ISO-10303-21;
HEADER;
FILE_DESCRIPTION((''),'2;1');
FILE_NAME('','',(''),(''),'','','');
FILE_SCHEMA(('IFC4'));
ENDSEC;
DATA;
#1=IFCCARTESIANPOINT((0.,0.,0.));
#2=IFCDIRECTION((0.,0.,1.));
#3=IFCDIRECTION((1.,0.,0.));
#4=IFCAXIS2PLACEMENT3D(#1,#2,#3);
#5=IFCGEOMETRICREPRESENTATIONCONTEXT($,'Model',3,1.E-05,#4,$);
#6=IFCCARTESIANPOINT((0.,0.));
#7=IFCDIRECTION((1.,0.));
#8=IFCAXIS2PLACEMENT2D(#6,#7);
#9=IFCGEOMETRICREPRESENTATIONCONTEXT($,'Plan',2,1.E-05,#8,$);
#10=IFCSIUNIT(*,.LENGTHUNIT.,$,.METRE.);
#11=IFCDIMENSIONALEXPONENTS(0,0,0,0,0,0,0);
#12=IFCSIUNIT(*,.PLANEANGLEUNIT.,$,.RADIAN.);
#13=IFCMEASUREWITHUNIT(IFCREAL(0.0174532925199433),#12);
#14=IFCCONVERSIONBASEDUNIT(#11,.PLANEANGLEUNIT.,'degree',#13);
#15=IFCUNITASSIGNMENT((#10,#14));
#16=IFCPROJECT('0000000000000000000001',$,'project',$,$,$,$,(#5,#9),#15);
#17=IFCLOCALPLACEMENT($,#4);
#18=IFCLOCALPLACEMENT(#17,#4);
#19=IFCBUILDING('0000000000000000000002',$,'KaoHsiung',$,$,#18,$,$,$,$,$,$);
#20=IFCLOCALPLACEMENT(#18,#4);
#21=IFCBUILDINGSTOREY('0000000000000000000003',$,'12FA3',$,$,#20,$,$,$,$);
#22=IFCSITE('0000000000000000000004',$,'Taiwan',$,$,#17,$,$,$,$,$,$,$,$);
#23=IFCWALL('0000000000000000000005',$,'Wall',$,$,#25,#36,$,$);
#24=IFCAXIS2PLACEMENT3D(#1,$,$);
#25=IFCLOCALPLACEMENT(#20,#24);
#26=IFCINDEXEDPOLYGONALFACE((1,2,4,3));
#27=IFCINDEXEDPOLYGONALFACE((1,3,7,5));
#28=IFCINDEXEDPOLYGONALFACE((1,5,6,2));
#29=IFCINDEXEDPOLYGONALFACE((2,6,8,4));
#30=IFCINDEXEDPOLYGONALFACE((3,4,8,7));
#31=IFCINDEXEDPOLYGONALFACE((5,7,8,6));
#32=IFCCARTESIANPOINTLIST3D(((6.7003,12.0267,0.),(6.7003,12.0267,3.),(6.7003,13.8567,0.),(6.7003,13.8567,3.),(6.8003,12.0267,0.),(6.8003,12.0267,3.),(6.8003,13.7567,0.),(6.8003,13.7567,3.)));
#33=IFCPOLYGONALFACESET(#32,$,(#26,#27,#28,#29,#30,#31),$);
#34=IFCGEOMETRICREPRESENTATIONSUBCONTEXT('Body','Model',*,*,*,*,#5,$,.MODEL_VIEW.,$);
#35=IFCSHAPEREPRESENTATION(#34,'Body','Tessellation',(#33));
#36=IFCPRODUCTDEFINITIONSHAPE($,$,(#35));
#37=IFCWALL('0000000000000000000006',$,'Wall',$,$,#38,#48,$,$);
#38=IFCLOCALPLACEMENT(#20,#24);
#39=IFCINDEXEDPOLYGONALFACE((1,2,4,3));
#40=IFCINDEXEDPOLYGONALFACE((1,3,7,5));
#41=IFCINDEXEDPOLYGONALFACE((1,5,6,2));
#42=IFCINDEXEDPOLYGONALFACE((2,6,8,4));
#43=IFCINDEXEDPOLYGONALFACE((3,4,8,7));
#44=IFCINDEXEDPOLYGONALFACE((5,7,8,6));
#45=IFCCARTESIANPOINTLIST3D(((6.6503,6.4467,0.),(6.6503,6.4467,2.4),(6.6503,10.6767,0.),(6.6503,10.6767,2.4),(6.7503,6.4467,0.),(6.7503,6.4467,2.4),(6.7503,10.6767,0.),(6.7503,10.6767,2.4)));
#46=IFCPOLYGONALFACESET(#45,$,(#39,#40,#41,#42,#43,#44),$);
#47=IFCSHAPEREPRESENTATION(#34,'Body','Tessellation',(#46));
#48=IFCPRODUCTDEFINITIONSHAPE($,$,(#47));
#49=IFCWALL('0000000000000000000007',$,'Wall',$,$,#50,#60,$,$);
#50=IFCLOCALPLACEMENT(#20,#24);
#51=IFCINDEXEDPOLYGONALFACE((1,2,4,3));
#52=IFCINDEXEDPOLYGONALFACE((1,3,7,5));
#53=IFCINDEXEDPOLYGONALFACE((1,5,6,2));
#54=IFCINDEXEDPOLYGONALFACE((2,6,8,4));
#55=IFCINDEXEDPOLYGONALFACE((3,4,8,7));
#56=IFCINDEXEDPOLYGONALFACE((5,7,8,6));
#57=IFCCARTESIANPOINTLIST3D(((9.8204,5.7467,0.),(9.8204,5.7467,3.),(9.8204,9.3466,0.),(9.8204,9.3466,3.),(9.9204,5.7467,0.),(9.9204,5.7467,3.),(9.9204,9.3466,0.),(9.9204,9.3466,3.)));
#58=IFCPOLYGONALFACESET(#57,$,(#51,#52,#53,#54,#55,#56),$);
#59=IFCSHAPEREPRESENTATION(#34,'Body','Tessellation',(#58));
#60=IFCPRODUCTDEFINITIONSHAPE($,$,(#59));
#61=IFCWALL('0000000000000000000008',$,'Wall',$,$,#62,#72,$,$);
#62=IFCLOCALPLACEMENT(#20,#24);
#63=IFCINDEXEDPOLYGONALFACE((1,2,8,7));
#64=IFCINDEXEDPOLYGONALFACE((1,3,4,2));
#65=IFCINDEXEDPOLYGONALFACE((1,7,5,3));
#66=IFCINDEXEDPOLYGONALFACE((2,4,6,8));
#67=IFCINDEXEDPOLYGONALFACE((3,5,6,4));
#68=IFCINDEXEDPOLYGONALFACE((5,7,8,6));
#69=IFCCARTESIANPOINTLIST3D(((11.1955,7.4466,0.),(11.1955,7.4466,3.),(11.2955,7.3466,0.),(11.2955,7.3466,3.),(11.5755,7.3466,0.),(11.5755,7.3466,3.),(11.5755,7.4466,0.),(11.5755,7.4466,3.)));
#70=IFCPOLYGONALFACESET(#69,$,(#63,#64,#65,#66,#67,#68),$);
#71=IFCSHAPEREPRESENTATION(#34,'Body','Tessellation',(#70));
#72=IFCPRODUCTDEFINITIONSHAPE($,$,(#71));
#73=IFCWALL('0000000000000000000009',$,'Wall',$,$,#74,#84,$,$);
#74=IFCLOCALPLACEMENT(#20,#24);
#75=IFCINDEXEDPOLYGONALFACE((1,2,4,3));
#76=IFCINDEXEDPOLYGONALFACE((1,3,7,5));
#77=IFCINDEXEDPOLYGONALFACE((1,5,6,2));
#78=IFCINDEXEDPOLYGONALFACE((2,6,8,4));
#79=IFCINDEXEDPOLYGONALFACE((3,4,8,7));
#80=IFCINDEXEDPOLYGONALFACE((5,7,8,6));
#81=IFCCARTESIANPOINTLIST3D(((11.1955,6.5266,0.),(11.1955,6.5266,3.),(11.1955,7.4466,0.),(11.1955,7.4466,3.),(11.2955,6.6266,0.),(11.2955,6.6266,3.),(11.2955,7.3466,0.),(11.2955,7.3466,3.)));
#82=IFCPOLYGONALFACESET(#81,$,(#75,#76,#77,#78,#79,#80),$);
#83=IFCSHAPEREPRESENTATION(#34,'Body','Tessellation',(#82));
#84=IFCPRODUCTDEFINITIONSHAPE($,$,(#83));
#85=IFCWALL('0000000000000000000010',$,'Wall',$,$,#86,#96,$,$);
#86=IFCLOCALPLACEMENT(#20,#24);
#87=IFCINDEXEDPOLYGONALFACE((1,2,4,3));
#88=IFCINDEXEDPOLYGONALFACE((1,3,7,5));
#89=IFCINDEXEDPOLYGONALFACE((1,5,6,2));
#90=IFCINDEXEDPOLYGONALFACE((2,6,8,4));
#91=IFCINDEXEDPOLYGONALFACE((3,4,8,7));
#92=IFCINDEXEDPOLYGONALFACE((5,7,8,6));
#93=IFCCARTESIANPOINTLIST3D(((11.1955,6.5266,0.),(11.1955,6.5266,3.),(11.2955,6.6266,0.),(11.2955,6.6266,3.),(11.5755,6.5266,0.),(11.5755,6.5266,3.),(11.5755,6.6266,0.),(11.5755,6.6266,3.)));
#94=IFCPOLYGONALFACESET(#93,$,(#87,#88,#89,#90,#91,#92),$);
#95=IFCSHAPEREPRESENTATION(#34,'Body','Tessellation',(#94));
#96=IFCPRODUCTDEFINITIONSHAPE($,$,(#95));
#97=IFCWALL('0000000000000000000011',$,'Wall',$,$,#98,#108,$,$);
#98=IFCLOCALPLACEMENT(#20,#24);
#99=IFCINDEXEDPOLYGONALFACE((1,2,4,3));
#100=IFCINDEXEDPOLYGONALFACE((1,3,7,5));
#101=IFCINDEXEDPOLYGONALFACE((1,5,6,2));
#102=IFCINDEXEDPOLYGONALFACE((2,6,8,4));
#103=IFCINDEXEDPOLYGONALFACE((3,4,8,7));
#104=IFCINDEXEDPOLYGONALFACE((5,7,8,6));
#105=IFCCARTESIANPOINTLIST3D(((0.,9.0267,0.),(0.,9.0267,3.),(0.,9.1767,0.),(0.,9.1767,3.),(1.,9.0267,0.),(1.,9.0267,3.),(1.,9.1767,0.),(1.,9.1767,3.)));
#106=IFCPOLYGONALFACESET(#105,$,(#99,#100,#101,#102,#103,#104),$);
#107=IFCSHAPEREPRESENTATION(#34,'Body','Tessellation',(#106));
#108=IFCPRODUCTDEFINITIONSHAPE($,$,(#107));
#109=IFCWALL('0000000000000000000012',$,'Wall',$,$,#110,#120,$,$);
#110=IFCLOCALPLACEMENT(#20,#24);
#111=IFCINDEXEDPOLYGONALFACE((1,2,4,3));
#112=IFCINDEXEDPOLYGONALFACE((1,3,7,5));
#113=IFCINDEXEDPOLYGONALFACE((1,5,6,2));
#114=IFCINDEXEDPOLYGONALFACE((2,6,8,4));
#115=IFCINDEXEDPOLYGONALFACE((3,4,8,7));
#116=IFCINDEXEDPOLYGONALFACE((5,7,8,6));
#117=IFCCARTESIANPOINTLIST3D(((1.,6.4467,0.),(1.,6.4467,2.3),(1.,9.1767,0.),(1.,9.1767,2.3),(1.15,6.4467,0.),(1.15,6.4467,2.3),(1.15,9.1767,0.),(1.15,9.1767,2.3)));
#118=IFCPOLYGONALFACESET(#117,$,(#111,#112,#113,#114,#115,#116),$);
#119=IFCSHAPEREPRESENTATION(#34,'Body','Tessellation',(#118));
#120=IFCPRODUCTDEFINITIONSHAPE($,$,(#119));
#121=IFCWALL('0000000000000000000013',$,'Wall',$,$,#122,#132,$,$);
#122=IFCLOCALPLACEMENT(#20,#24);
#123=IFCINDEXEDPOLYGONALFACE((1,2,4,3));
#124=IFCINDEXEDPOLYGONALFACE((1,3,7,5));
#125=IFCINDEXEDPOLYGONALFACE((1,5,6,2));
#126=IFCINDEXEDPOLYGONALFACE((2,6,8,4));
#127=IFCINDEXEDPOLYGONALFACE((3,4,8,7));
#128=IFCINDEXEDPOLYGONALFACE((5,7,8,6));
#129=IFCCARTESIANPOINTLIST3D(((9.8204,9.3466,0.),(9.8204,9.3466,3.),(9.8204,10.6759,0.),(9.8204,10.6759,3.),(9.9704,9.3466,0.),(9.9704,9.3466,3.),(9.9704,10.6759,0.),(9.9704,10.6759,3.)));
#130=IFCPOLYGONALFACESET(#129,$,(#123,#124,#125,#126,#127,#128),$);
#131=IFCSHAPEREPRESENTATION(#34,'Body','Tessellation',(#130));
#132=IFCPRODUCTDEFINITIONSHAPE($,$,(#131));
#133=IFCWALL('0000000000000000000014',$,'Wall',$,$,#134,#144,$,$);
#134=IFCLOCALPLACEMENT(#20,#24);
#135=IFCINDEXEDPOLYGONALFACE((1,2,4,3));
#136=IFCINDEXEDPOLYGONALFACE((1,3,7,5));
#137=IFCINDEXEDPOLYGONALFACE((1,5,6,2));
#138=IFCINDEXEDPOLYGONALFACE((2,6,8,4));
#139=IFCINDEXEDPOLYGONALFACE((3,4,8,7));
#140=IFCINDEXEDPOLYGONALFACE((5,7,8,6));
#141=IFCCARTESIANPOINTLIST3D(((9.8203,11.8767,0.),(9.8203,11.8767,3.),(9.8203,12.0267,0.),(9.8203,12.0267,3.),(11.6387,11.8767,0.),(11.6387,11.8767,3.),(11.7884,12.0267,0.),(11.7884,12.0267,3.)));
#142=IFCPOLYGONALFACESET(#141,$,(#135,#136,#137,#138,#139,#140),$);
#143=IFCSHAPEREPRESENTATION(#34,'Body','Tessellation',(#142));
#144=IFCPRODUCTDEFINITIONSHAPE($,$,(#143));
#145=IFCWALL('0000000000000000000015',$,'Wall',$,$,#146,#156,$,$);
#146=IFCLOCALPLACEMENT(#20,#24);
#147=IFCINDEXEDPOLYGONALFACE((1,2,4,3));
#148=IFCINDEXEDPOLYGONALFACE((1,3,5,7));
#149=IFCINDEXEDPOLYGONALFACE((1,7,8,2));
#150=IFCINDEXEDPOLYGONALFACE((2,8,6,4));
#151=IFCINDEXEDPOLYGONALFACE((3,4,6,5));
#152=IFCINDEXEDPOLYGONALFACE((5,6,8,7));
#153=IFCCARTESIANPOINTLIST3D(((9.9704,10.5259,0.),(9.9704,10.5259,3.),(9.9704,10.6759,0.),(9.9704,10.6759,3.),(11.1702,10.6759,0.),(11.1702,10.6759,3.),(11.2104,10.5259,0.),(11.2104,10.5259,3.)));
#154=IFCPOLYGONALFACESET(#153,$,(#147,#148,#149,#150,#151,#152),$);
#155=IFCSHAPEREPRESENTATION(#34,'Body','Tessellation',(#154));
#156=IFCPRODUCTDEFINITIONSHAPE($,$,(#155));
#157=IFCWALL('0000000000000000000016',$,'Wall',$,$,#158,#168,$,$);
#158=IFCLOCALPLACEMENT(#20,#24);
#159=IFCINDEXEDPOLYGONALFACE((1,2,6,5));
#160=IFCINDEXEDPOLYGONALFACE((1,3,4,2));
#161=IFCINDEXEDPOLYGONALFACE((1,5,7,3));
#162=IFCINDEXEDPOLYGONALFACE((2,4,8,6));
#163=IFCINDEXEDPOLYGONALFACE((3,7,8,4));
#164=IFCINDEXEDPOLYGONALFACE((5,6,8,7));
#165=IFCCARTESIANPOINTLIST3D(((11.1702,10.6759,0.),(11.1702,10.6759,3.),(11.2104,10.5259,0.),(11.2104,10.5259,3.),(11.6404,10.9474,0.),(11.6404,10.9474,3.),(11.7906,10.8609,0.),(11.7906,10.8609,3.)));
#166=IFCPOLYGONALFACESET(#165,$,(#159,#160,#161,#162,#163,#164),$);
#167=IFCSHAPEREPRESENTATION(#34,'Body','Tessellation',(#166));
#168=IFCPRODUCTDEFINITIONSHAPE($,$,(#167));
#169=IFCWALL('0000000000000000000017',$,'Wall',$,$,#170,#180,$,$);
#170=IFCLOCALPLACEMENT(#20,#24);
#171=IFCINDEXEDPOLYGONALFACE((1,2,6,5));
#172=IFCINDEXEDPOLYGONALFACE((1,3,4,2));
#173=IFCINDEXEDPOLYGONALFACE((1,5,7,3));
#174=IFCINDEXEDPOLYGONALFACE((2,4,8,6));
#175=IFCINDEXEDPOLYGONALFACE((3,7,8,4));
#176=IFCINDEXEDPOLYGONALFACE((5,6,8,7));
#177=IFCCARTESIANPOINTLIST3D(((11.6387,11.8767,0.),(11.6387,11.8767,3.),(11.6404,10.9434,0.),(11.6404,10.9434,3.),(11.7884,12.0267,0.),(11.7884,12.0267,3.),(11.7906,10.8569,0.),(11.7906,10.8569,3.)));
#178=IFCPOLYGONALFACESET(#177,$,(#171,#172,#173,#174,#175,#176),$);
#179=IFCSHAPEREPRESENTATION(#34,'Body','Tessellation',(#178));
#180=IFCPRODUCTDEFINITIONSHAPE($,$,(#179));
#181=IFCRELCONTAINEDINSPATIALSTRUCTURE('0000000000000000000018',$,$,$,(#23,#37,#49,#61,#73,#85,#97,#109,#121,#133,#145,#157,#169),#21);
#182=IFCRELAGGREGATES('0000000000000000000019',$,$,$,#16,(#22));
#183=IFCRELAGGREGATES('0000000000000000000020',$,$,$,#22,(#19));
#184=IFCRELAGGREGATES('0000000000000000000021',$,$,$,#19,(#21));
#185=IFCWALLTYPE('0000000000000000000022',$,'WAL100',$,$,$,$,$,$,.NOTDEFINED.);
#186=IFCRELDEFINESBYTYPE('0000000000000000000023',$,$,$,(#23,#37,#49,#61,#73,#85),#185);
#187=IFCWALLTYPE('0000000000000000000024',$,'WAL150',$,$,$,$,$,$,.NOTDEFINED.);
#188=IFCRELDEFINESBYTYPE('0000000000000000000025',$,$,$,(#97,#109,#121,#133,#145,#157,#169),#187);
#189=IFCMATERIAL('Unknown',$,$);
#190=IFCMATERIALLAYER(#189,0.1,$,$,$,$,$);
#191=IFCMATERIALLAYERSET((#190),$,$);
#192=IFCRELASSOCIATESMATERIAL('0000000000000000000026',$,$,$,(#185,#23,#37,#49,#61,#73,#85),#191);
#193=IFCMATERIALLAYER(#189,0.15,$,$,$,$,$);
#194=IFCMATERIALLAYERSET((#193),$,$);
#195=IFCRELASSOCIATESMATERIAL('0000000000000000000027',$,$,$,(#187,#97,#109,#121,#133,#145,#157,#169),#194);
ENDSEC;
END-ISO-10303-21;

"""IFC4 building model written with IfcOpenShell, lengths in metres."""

from ifc_helpers import new_model, entity, si_unit, converted_unit, frame, origin_with_axes, origin_2d_with_axis, place, context, subcontext, project, spatial, line, indexed_curve, outline, extrude, material, layer, layer_set, layer_usage, type_object, element, save


model = new_model("IFC4")

# Units and contexts
model_context = context("Model", 3, precision=1e-05, world=origin_with_axes())
plan_context = context("Plan", 2, precision=1e-05, world=origin_2d_with_axis())
body_context = subcontext(model_context, "Body", "Model", "MODEL_VIEW")
ifc_project = project(units=[si_unit("LENGTHUNIT", "METRE"), converted_unit("PLANEANGLEUNIT", "degree", entity("IfcReal", 0.0174532925199433), si_unit("PLANEANGLEUNIT", "RADIAN"), dimensions=[0, 0, 0, 0, 0, 0, 0])], contexts=[model_context, plan_context])

# Site, building, storey
site_placement = place(None, origin_with_axes())
site = spatial("IfcSite", under=ifc_project, at=site_placement, Name="Taiwan")
building_placement = place(site_placement, origin_with_axes())
building = spatial("IfcBuilding", under=site, at=building_placement, Name="KaoHsiung")
storey_placement = place(building_placement, origin_with_axes())
storey = spatial("IfcBuildingStorey", under=building, at=storey_placement, Name="12FA3")

# Shared definitions
ifc_material = material(Name="Unknown")

# Walls
ifc_layer_1 = layer(ifc_material, 0.1)
ifc_layer_set_1 = layer_set([ifc_layer_1])
wall_type_1 = type_object("IfcWallType", Name="WAL100", PredefinedType="NOTDEFINED", material=ifc_layer_set_1)
ifc_layer_usage_1 = layer_usage(ifc_layer_set_1, "AXIS2", "POSITIVE", 0.0)
wall_1_placement = place(storey_placement, frame((6.7003, 13.8567, 0.0), z_axis=(0.0, 0.0, 1.0), x_axis=(0.0, -1.0, 0.0)))
element("IfcWall", 1, at=wall_1_placement, inside=storey, type_object=wall_type_1, material=ifc_layer_usage_1, Name="Wall", context=body_context, shape_type="SweptSolid", body=[
    extrude(outline(indexed_curve([(0.0, 0.0), (0.1, 0.1), (1.8299, 0.1), (1.8299, 0.0)], segments=[line(1, 2, 3, 4, 1)])), origin_with_axes(), (0.0, 0.0, 1.0), 3.0),
])
ifc_layer_usage_2 = layer_usage(ifc_layer_set_1, "AXIS2", "POSITIVE", 0.0)
wall_2_placement = place(storey_placement, frame((6.6503, 10.6767, 0.0), z_axis=(0.0, 0.0, 1.0), x_axis=(0.0, -1.0, 0.0)))
element("IfcWall", 2, at=wall_2_placement, inside=storey, type_object=wall_type_1, material=ifc_layer_usage_2, Name="Wall", context=body_context, shape_type="SweptSolid", body=[
    extrude(outline(indexed_curve([(0.0, 0.0), (0.0, 0.1), (4.23, 0.1), (4.23, 0.0)], segments=[line(1, 2, 3, 4, 1)])), origin_with_axes(), (0.0, 0.0, 1.0), 2.4),
])
ifc_layer_usage_3 = layer_usage(ifc_layer_set_1, "AXIS2", "POSITIVE", 0.0)
wall_3_placement = place(storey_placement, frame((9.8204, 9.3466, 0.0), z_axis=(0.0, 0.0, 1.0), x_axis=(0.0, -1.0, 0.0)))
element("IfcWall", 3, at=wall_3_placement, inside=storey, type_object=wall_type_1, material=ifc_layer_usage_3, Name="Wall", context=body_context, shape_type="SweptSolid", body=[
    extrude(outline(indexed_curve([(0.0, 0.0), (0.0, 0.1), (3.5999, 0.1), (3.5999, 0.0)], segments=[line(1, 2, 3, 4, 1)])), origin_with_axes(), (0.0, 0.0, 1.0), 3.0),
])
ifc_layer_usage_4 = layer_usage(ifc_layer_set_1, "AXIS2", "POSITIVE", 0.0)
wall_4_placement = place(storey_placement, frame((11.5755, 7.4466, 0.0), z_axis=(0.0, 0.0, 1.0), x_axis=(-1.0, 0.0, 0.0)))
element("IfcWall", 4, at=wall_4_placement, inside=storey, type_object=wall_type_1, material=ifc_layer_usage_4, Name="Wall", context=body_context, shape_type="SweptSolid", body=[
    extrude(outline(indexed_curve([(0.0, 0.0), (0.0, 0.1), (0.28, 0.1), (0.38, 0.0)], segments=[line(1, 2, 3, 4, 1)])), origin_with_axes(), (0.0, 0.0, 1.0), 3.0),
])
ifc_layer_usage_5 = layer_usage(ifc_layer_set_1, "AXIS2", "POSITIVE", 0.0)
wall_5_placement = place(storey_placement, frame((11.1955, 7.4466, 0.0), z_axis=(0.0, 0.0, 1.0), x_axis=(0.0, -1.0, 0.0)))
element("IfcWall", 5, at=wall_5_placement, inside=storey, type_object=wall_type_1, material=ifc_layer_usage_5, Name="Wall", context=body_context, shape_type="SweptSolid", body=[
    extrude(outline(indexed_curve([(0.0, 0.0), (0.1, 0.1), (0.82, 0.1), (0.92, 0.0)], segments=[line(1, 2, 3, 4, 1)])), origin_with_axes(), (0.0, 0.0, 1.0), 3.0),
])
ifc_layer_usage_6 = layer_usage(ifc_layer_set_1, "AXIS2", "POSITIVE", 0.0)
wall_6_placement = place(storey_placement, frame((11.1955, 6.5266, 0.0), z_axis=(0.0, 0.0, 1.0), x_axis=(1.0, 0.0, 0.0)))
element("IfcWall", 6, at=wall_6_placement, inside=storey, type_object=wall_type_1, material=ifc_layer_usage_6, Name="Wall", context=body_context, shape_type="SweptSolid", body=[
    extrude(outline(indexed_curve([(0.0, 0.0), (0.1, 0.1), (0.38, 0.1), (0.38, 0.0)], segments=[line(1, 2, 3, 4, 1)])), origin_with_axes(), (0.0, 0.0, 1.0), 3.0),
])
ifc_layer_2 = layer(ifc_material, 0.15)
ifc_layer_set_2 = layer_set([ifc_layer_2])
ifc_layer_usage_7 = layer_usage(ifc_layer_set_2, "AXIS2", "POSITIVE", 0.0)
wall_type_2 = type_object("IfcWallType", Name="WAL150", PredefinedType="NOTDEFINED", material=ifc_layer_set_2)
wall_7_placement = place(storey_placement, frame((0.0, 9.0267, 0.0), z_axis=(0.0, 0.0, 1.0), x_axis=(1.0, 0.0, 0.0)))
element("IfcWall", 7, at=wall_7_placement, inside=storey, type_object=wall_type_2, material=ifc_layer_usage_7, Name="Wall", context=body_context, shape_type="SweptSolid", body=[
    extrude(outline(indexed_curve([(0.0, 0.0), (0.0, 0.15), (1.0, 0.15), (1.0, 0.0)], segments=[line(1, 2, 3, 4, 1)])), origin_with_axes(), (0.0, 0.0, 1.0), 3.0),
])
ifc_layer_usage_8 = layer_usage(ifc_layer_set_2, "AXIS2", "POSITIVE", 0.0)
wall_8_placement = place(storey_placement, frame((1.0, 9.1767, 0.0), z_axis=(0.0, 0.0, 1.0), x_axis=(0.0, -1.0, 0.0)))
element("IfcWall", 8, at=wall_8_placement, inside=storey, type_object=wall_type_2, material=ifc_layer_usage_8, Name="Wall", context=body_context, shape_type="SweptSolid", body=[
    extrude(outline(indexed_curve([(0.0, 0.0), (0.0, 0.15), (2.73, 0.15), (2.73, 0.0)], segments=[line(1, 2, 3, 4, 1)])), origin_with_axes(), (0.0, 0.0, 1.0), 2.3),
])
ifc_layer_usage_9 = layer_usage(ifc_layer_set_2, "AXIS2", "POSITIVE", 0.0)
wall_9_placement = place(storey_placement, frame((9.9704, 9.3466, 0.0), z_axis=(0.0, 0.0, 1.0), x_axis=(0.0, 1.0, 0.0)))
element("IfcWall", 9, at=wall_9_placement, inside=storey, type_object=wall_type_2, material=ifc_layer_usage_9, Name="Wall", context=body_context, shape_type="SweptSolid", body=[
    extrude(outline(indexed_curve([(0.0, 0.0), (0.0, 0.15), (1.3293, 0.15), (1.3293, 0.0)], segments=[line(1, 2, 3, 4, 1)])), origin_with_axes(), (0.0, 0.0, 1.0), 3.0),
])
ifc_layer_usage_10 = layer_usage(ifc_layer_set_2, "AXIS2", "POSITIVE", 0.0)
wall_10_placement = place(storey_placement, frame((11.7884, 12.0267, 0.0), z_axis=(0.0, 0.0, 1.0), x_axis=(-1.0, 0.0, 0.0)))
element("IfcWall", 10, at=wall_10_placement, inside=storey, type_object=wall_type_2, material=ifc_layer_usage_10, Name="Wall", context=body_context, shape_type="SweptSolid", body=[
    extrude(outline(indexed_curve([(0.0, 0.0), (0.1497, 0.15), (1.9681, 0.15), (1.9681, 0.0)], segments=[line(1, 2, 3, 4, 1)])), origin_with_axes(), (0.0, 0.0, 1.0), 3.0),
])
ifc_layer_usage_11 = layer_usage(ifc_layer_set_2, "AXIS2", "POSITIVE", 0.0)
wall_11_placement = place(storey_placement, frame((9.9704, 10.5259, 0.0), z_axis=(0.0, 0.0, 1.0), x_axis=(1.0, 0.0, 0.0)))
element("IfcWall", 11, at=wall_11_placement, inside=storey, type_object=wall_type_2, material=ifc_layer_usage_11, Name="Wall", context=body_context, shape_type="SweptSolid", body=[
    extrude(outline(indexed_curve([(0.0, 0.0), (0.0, 0.15), (1.1998, 0.15), (1.24, 0.0)], segments=[line(1, 2, 3, 4, 1)])), origin_with_axes(), (0.0, 0.0, 1.0), 3.0),
])
ifc_layer_usage_12 = layer_usage(ifc_layer_set_2, "AXIS2", "POSITIVE", 0.0)
wall_12_placement = place(storey_placement, frame((11.2104, 10.5259, 0.0), z_axis=(0.0, 0.0, 1.0), x_axis=(0.866026, 0.5, 0.0)))
element("IfcWall", 12, at=wall_12_placement, inside=storey, type_object=wall_type_2, material=ifc_layer_usage_12, Name="Wall", context=body_context, shape_type="SweptSolid", body=[
    extrude(outline(indexed_curve([(0.0, 0.0), (0.0402, 0.15), (0.5832, 0.15), (0.67, 0.0)], segments=[line(1, 2, 3, 4, 1)])), origin_with_axes(), (0.0, 0.0, 1.0), 3.0),
])
ifc_layer_usage_13 = layer_usage(ifc_layer_set_2, "AXIS2", "POSITIVE", 0.0)
wall_13_placement = place(storey_placement, frame((11.7906, 10.8569, 0.0), z_axis=(0.0, 0.0, 1.0), x_axis=(-0.001882, 0.999998, 0.0)))
element("IfcWall", 13, at=wall_13_placement, inside=storey, type_object=wall_type_2, material=ifc_layer_usage_13, Name="Wall", context=body_context, shape_type="SweptSolid", body=[
    extrude(outline(indexed_curve([(0.0, 0.0), (0.0868, 0.15), (1.02, 0.15), (1.1698, 0.0)], segments=[line(1, 2, 3, 4, 1)])), origin_with_axes(), (0.0, 0.0, 1.0), 3.0),
])

save(model, "model.ifc")
